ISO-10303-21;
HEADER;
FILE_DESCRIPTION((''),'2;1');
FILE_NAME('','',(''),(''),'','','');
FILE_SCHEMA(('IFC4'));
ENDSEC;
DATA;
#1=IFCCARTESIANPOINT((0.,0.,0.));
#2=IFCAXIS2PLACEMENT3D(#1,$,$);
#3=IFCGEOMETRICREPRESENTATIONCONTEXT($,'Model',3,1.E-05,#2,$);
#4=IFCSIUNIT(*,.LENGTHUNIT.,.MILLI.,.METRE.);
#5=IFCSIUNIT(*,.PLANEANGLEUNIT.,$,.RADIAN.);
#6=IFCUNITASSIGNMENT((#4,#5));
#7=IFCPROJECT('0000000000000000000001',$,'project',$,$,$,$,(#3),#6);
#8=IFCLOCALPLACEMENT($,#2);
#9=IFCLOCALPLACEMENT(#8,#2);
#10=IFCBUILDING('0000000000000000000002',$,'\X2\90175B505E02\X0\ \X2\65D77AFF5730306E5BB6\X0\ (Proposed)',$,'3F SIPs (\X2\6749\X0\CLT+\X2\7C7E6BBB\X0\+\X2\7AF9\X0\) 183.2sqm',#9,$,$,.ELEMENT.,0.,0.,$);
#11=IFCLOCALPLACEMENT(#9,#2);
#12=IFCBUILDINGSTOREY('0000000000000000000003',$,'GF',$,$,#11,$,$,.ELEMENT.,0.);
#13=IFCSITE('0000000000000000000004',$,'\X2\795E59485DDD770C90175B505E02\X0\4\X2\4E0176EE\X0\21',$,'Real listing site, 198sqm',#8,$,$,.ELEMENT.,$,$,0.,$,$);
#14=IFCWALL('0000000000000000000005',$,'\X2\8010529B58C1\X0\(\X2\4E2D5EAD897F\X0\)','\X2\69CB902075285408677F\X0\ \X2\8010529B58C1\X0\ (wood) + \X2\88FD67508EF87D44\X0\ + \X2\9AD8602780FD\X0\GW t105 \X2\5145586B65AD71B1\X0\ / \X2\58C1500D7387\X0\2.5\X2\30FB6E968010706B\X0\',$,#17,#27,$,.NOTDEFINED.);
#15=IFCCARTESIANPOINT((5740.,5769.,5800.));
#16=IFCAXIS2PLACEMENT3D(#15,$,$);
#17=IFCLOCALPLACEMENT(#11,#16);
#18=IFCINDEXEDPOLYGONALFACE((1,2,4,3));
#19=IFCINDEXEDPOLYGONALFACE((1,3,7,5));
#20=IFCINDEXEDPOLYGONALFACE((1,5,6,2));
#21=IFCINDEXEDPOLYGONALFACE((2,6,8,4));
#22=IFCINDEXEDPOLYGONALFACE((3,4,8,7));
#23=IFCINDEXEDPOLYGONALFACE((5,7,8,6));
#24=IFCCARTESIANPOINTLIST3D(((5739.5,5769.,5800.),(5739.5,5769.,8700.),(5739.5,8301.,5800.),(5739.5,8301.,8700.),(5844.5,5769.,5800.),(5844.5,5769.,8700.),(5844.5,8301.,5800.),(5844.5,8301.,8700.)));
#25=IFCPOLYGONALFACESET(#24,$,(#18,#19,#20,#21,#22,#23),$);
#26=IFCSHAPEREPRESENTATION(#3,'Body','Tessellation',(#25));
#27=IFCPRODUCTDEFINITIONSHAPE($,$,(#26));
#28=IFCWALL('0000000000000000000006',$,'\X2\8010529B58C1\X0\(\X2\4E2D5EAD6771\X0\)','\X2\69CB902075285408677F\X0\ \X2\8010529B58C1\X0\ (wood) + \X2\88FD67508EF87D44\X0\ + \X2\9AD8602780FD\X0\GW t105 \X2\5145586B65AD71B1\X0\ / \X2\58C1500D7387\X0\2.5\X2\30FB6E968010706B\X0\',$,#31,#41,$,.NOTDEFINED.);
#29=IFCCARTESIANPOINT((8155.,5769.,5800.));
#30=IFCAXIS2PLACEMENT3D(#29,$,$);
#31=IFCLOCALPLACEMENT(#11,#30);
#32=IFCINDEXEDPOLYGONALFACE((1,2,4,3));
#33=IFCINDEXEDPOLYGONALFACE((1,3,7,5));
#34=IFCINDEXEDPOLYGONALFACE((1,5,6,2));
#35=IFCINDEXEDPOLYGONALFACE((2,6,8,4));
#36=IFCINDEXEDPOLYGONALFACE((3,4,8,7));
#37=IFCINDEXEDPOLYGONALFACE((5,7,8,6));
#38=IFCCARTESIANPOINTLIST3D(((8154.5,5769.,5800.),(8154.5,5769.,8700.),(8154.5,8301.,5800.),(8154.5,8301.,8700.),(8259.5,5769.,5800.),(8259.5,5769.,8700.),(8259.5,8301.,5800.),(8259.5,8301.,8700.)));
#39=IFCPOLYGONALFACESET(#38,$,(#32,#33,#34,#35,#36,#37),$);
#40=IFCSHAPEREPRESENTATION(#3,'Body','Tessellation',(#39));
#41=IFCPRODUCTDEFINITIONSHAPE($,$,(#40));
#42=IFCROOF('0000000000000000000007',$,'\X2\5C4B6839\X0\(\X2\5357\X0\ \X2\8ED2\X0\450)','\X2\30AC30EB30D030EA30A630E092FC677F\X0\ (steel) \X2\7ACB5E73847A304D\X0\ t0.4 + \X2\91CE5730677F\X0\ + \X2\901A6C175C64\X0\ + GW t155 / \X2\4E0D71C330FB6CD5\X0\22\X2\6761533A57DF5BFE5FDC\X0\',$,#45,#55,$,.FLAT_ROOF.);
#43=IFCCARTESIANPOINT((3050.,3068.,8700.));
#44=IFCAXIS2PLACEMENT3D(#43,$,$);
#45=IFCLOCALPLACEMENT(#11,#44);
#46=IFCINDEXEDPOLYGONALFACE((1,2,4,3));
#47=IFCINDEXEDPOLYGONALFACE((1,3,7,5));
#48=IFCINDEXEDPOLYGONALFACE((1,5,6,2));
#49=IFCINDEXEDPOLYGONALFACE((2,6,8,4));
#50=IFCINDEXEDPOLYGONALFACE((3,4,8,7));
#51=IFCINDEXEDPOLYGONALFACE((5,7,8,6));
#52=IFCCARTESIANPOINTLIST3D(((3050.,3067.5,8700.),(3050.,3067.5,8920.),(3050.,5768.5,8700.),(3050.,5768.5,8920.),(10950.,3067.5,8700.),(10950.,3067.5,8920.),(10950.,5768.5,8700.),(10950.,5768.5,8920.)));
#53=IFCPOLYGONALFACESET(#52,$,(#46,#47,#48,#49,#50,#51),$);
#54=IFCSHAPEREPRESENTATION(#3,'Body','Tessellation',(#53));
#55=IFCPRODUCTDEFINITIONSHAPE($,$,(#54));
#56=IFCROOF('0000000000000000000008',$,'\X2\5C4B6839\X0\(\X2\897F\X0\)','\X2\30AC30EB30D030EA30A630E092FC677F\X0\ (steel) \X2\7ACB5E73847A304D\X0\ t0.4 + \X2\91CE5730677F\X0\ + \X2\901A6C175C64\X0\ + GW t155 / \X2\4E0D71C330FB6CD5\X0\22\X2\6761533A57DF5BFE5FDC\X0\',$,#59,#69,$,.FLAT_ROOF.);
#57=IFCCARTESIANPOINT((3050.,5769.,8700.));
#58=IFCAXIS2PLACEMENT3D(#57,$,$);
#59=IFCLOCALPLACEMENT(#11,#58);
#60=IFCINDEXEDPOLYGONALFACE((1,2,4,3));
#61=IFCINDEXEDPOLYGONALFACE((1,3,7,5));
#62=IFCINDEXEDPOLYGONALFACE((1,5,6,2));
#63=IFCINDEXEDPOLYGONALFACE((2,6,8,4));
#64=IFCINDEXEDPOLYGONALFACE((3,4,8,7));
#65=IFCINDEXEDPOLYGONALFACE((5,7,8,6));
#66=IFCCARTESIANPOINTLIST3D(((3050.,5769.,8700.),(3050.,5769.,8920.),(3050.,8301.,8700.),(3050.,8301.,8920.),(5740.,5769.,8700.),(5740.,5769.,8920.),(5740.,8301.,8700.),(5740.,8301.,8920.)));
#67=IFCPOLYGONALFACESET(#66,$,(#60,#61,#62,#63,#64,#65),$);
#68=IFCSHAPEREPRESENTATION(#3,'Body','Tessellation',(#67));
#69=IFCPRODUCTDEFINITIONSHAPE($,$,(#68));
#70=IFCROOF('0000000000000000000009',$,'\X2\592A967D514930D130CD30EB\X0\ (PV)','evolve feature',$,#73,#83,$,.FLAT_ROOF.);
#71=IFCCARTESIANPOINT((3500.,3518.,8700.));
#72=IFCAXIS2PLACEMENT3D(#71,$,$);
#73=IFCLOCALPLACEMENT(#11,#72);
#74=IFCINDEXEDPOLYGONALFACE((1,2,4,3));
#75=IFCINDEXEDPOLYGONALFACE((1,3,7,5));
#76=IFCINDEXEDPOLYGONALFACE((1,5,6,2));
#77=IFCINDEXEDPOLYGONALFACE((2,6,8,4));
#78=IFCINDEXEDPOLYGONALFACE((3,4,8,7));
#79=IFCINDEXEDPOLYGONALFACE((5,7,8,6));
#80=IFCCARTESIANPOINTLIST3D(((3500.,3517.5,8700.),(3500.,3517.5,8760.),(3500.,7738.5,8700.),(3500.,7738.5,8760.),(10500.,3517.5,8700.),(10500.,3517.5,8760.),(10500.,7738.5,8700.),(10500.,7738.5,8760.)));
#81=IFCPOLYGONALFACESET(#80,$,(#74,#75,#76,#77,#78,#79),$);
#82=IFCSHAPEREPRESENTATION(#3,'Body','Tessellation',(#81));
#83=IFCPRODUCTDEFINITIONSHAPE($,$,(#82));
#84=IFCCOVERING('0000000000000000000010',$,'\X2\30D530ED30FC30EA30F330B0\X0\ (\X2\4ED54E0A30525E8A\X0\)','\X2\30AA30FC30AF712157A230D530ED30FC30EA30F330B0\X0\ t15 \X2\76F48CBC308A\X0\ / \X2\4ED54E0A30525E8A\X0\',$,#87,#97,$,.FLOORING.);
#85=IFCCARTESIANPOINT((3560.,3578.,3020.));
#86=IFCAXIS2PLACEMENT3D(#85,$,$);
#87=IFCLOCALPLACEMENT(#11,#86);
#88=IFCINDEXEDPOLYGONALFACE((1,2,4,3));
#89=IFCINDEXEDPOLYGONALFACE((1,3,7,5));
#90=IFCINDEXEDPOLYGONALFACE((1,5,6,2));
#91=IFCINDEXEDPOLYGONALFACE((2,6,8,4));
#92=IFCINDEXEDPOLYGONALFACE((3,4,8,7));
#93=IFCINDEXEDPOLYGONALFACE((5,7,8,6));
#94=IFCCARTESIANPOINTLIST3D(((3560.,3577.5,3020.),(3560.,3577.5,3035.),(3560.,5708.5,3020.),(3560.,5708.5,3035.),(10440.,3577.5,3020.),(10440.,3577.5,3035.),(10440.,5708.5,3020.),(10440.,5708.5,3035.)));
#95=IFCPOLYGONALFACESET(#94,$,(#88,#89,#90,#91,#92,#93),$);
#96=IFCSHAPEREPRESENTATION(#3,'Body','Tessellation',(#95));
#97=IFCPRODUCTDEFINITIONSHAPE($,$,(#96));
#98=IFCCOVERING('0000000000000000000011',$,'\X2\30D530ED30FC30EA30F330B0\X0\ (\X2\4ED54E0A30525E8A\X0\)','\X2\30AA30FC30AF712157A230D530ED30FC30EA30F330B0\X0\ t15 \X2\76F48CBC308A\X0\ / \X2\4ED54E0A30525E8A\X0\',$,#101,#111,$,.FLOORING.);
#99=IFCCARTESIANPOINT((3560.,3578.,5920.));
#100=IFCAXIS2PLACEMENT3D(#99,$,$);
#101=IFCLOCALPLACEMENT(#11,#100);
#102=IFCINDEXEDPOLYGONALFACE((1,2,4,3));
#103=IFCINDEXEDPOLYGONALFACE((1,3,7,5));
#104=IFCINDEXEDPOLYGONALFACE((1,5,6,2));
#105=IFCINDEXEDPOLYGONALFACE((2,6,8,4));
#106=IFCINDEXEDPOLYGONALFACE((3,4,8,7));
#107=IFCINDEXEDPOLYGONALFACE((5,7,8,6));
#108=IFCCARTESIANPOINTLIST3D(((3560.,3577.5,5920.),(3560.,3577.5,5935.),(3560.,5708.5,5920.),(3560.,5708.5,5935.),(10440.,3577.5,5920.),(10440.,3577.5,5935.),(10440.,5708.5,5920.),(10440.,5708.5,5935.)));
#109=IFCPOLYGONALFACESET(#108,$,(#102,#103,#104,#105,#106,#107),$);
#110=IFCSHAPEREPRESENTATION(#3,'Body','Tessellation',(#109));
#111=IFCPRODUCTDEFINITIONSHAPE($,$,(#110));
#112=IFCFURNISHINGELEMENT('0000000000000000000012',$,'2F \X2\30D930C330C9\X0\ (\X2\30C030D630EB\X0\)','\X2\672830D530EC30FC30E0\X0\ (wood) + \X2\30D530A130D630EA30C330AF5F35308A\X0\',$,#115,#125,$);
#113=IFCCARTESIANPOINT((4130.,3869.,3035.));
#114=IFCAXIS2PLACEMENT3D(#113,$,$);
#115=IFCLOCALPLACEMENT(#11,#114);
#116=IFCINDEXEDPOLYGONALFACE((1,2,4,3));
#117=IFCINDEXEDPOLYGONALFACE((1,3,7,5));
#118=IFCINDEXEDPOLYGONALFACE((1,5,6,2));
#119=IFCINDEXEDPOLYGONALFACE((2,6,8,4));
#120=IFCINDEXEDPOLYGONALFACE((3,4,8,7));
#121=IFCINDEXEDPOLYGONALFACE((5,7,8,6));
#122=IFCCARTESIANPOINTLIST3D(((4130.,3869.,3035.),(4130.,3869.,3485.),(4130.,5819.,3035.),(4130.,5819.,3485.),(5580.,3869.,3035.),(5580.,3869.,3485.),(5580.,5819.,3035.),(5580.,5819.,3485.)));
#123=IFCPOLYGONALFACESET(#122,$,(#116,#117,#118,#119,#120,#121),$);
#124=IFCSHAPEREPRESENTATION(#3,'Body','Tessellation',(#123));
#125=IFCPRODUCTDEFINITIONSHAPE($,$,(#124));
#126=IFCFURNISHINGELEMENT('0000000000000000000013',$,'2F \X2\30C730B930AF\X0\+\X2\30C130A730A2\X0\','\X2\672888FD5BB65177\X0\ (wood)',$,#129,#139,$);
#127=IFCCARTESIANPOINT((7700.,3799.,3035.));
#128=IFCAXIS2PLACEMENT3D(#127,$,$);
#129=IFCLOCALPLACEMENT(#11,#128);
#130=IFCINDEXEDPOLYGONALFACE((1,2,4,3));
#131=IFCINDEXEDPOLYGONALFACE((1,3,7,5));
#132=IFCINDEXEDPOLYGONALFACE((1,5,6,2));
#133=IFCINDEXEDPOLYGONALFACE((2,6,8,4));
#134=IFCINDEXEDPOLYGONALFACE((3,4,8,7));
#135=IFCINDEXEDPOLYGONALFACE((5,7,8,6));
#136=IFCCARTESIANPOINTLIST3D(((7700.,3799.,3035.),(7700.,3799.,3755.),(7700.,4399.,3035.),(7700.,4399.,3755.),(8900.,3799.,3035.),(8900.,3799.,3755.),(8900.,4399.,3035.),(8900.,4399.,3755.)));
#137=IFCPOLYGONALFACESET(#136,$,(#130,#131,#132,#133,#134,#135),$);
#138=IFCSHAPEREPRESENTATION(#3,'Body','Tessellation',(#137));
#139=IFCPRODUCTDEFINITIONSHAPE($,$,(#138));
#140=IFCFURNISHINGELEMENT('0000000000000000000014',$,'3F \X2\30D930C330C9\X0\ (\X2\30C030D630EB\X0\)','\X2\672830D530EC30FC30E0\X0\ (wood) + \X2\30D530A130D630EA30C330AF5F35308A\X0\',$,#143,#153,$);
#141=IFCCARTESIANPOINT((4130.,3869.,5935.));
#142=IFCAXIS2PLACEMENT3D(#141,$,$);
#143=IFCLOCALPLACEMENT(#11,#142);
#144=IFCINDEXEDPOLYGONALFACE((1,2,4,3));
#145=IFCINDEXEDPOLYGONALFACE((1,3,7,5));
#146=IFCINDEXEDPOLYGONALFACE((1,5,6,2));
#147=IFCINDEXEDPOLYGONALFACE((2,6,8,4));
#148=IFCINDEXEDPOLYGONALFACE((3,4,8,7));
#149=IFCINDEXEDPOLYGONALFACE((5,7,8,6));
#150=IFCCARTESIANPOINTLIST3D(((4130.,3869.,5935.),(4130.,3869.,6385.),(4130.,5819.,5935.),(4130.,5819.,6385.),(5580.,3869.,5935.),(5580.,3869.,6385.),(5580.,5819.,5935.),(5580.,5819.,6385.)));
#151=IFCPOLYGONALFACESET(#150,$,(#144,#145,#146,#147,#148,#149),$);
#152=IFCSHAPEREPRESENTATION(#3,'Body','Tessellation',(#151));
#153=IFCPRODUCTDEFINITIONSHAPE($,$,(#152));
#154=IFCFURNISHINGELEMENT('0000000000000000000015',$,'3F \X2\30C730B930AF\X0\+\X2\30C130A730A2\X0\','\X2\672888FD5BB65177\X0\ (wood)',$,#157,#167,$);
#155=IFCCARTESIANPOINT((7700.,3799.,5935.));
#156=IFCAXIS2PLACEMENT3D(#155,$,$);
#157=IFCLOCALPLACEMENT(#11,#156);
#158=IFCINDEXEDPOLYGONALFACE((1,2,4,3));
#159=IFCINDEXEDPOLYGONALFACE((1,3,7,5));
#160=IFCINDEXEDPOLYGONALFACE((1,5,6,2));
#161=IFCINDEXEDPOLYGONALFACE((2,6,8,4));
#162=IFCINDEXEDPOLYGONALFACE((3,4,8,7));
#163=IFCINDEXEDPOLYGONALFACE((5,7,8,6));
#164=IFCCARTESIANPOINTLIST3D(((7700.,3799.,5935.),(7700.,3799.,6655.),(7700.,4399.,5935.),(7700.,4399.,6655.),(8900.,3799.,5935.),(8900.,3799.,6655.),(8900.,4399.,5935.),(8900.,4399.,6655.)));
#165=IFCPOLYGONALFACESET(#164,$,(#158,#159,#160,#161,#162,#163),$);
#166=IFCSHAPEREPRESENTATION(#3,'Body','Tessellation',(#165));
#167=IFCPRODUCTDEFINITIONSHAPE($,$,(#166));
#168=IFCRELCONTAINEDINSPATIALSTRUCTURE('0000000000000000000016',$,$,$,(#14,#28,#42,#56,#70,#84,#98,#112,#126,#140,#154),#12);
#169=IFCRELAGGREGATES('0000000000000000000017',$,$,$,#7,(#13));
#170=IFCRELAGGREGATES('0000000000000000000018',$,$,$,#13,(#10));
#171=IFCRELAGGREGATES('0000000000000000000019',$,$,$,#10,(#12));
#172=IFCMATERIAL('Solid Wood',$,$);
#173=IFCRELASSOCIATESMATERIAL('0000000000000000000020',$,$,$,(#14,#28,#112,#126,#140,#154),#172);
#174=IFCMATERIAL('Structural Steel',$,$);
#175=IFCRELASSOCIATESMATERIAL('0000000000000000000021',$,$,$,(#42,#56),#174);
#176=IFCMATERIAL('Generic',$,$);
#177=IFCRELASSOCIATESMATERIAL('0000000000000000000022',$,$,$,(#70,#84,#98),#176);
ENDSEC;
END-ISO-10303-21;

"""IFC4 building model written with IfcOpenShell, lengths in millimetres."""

from ifc_helpers import new_model, si_unit, frame, frame_2d, origin, place, context, project, spatial, rectangle, extrude, material, element, save


model = new_model("IFC4")

# Units and contexts
model_context = context("Model", 3, precision=1e-05, world=origin())
ifc_project = project(units=[si_unit("LENGTHUNIT", "METRE", prefix="MILLI"), si_unit("PLANEANGLEUNIT", "RADIAN")], contexts=[model_context])

# Site, building, storey
site_placement = place(None, origin())
site = spatial("IfcSite", under=ifc_project, at=site_placement, Name="神奈川県逗子市4丁目21", ObjectType="Real listing site, 198sqm", CompositionType="ELEMENT", RefElevation=0.0)
building_placement = place(site_placement, origin())
building = spatial("IfcBuilding", under=site, at=building_placement, Name="逗子市 旗竿地の家 (Proposed)", ObjectType="3F SIPs (杉CLT+籾殻+竹) 183.2sqm", CompositionType="ELEMENT", ElevationOfRefHeight=0.0, ElevationOfTerrain=0.0)
storey_placement = place(building_placement, origin())
storey = spatial("IfcBuildingStorey", under=building, at=storey_placement, Name="GF", CompositionType="ELEMENT", Elevation=0.0)

# Shared definitions
ifc_material_1 = material(Name="Solid Wood")

# Walls
wall_1_placement = place(storey_placement, frame((5740.0, 5769.0, 5800.0)))
element("IfcWall", 1, at=wall_1_placement, inside=storey, material=ifc_material_1, Name="耐力壁(中庭西)", Description="構造用合板 耐力壁 (wood) + 製材軸組 + 高性能GW t105 充填断熱 / 壁倍率2.5・準耐火", PredefinedType="NOTDEFINED", context=model_context, shape_type="SweptSolid", body=[
    extrude(rectangle(XDim=105.0, YDim=2532.0, at=frame_2d((52.0, 1266.0))), frame((5740.0, 5769.0, 5800.0)), (0.0, 0.0, 1.0), 2900.0),
])
wall_2_placement = place(storey_placement, frame((8155.0, 5769.0, 5800.0)))
element("IfcWall", 2, at=wall_2_placement, inside=storey, material=ifc_material_1, Name="耐力壁(中庭東)", Description="構造用合板 耐力壁 (wood) + 製材軸組 + 高性能GW t105 充填断熱 / 壁倍率2.5・準耐火", PredefinedType="NOTDEFINED", context=model_context, shape_type="SweptSolid", body=[
    extrude(rectangle(XDim=105.0, YDim=2532.0, at=frame_2d((52.0, 1266.0))), frame((8155.0, 5769.0, 5800.0)), (0.0, 0.0, 1.0), 2900.0),
])

# Roofs
ifc_material_2 = material(Name="Structural Steel")
roof_1_placement = place(storey_placement, frame((3050.0, 3068.0, 8700.0)))
element("IfcRoof", 3, at=roof_1_placement, inside=storey, material=ifc_material_2, Name="屋根(南 軒450)", Description="ガルバリウム鋼板 (steel) 立平葺き t0.4 + 野地板 + 通気層 + GW t155 / 不燃・法22条区域対応", PredefinedType="FLAT_ROOF", context=model_context, shape_type="SweptSolid", body=[
    extrude(rectangle(XDim=7900.0, YDim=2701.0, at=frame_2d((3950.0, 1350.0))), frame((3050.0, 3068.0, 8700.0)), (0.0, 0.0, 1.0), 220.0),
])
roof_2_placement = place(storey_placement, frame((3050.0, 5769.0, 8700.0)))
element("IfcRoof", 4, at=roof_2_placement, inside=storey, material=ifc_material_2, Name="屋根(西)", Description="ガルバリウム鋼板 (steel) 立平葺き t0.4 + 野地板 + 通気層 + GW t155 / 不燃・法22条区域対応", PredefinedType="FLAT_ROOF", context=model_context, shape_type="SweptSolid", body=[
    extrude(rectangle(XDim=2690.0, YDim=2532.0, at=frame_2d((1345.0, 1266.0))), frame((3050.0, 5769.0, 8700.0)), (0.0, 0.0, 1.0), 220.0),
])
ifc_material_3 = material(Name="Generic")
roof_3_placement = place(storey_placement, frame((3500.0, 3518.0, 8700.0)))
element("IfcRoof", 5, at=roof_3_placement, inside=storey, material=ifc_material_3, Name="太陽光パネル (PV)", Description="evolve feature", PredefinedType="FLAT_ROOF", context=model_context, shape_type="SweptSolid", body=[
    extrude(rectangle(XDim=7000.0, YDim=4221.0, at=frame_2d((3500.0, 2110.0))), frame((3500.0, 3518.0, 8700.0)), (0.0, 0.0, 1.0), 60.0),
])

# Coverings
covering_1_placement = place(storey_placement, frame((3560.0, 3578.0, 3020.0)))
element("IfcCovering", 6, at=covering_1_placement, inside=storey, material=ifc_material_3, Name="フローリング (仕上げ床)", Description="オーク無垢フローリング t15 直貼り / 仕上げ床", PredefinedType="FLOORING", context=model_context, shape_type="SweptSolid", body=[
    extrude(rectangle(XDim=6880.0, YDim=2131.0, at=frame_2d((3440.0, 1065.0))), frame((3560.0, 3578.0, 3020.0)), (0.0, 0.0, 1.0), 15.0),
])
covering_2_placement = place(storey_placement, frame((3560.0, 3578.0, 5920.0)))
element("IfcCovering", 7, at=covering_2_placement, inside=storey, material=ifc_material_3, Name="フローリング (仕上げ床)", Description="オーク無垢フローリング t15 直貼り / 仕上げ床", PredefinedType="FLOORING", context=model_context, shape_type="SweptSolid", body=[
    extrude(rectangle(XDim=6880.0, YDim=2131.0, at=frame_2d((3440.0, 1065.0))), frame((3560.0, 3578.0, 5920.0)), (0.0, 0.0, 1.0), 15.0),
])

# Furnishing elements
furnishing_1_placement = place(storey_placement, frame((4130.0, 3869.0, 3035.0)))
element("IfcFurnishingElement", 8, at=furnishing_1_placement, inside=storey, material=ifc_material_1, Name="2F ベッド (ダブル)", Description="木フレーム (wood) + ファブリック張り", context=model_context, shape_type="SweptSolid", body=[
    extrude(rectangle(XDim=1450.0, YDim=1950.0, at=frame_2d((725.0, 975.0))), frame((4130.0, 3869.0, 3035.0)), (0.0, 0.0, 1.0), 450.0),
])
furnishing_2_placement = place(storey_placement, frame((7700.0, 3799.0, 3035.0)))
element("IfcFurnishingElement", 9, at=furnishing_2_placement, inside=storey, material=ifc_material_1, Name="2F デスク+チェア", Description="木製家具 (wood)", context=model_context, shape_type="SweptSolid", body=[
    extrude(rectangle(XDim=1200.0, YDim=600.0, at=frame_2d((600.0, 300.0))), frame((7700.0, 3799.0, 3035.0)), (0.0, 0.0, 1.0), 720.0),
])
furnishing_3_placement = place(storey_placement, frame((4130.0, 3869.0, 5935.0)))
element("IfcFurnishingElement", 10, at=furnishing_3_placement, inside=storey, material=ifc_material_1, Name="3F ベッド (ダブル)", Description="木フレーム (wood) + ファブリック張り", context=model_context, shape_type="SweptSolid", body=[
    extrude(rectangle(XDim=1450.0, YDim=1950.0, at=frame_2d((725.0, 975.0))), frame((4130.0, 3869.0, 5935.0)), (0.0, 0.0, 1.0), 450.0),
])
furnishing_4_placement = place(storey_placement, frame((7700.0, 3799.0, 5935.0)))
element("IfcFurnishingElement", 11, at=furnishing_4_placement, inside=storey, material=ifc_material_1, Name="3F デスク+チェア", Description="木製家具 (wood)", context=model_context, shape_type="SweptSolid", body=[
    extrude(rectangle(XDim=1200.0, YDim=600.0, at=frame_2d((600.0, 300.0))), frame((7700.0, 3799.0, 5935.0)), (0.0, 0.0, 1.0), 720.0),
])

save(model, "model.ifc")
